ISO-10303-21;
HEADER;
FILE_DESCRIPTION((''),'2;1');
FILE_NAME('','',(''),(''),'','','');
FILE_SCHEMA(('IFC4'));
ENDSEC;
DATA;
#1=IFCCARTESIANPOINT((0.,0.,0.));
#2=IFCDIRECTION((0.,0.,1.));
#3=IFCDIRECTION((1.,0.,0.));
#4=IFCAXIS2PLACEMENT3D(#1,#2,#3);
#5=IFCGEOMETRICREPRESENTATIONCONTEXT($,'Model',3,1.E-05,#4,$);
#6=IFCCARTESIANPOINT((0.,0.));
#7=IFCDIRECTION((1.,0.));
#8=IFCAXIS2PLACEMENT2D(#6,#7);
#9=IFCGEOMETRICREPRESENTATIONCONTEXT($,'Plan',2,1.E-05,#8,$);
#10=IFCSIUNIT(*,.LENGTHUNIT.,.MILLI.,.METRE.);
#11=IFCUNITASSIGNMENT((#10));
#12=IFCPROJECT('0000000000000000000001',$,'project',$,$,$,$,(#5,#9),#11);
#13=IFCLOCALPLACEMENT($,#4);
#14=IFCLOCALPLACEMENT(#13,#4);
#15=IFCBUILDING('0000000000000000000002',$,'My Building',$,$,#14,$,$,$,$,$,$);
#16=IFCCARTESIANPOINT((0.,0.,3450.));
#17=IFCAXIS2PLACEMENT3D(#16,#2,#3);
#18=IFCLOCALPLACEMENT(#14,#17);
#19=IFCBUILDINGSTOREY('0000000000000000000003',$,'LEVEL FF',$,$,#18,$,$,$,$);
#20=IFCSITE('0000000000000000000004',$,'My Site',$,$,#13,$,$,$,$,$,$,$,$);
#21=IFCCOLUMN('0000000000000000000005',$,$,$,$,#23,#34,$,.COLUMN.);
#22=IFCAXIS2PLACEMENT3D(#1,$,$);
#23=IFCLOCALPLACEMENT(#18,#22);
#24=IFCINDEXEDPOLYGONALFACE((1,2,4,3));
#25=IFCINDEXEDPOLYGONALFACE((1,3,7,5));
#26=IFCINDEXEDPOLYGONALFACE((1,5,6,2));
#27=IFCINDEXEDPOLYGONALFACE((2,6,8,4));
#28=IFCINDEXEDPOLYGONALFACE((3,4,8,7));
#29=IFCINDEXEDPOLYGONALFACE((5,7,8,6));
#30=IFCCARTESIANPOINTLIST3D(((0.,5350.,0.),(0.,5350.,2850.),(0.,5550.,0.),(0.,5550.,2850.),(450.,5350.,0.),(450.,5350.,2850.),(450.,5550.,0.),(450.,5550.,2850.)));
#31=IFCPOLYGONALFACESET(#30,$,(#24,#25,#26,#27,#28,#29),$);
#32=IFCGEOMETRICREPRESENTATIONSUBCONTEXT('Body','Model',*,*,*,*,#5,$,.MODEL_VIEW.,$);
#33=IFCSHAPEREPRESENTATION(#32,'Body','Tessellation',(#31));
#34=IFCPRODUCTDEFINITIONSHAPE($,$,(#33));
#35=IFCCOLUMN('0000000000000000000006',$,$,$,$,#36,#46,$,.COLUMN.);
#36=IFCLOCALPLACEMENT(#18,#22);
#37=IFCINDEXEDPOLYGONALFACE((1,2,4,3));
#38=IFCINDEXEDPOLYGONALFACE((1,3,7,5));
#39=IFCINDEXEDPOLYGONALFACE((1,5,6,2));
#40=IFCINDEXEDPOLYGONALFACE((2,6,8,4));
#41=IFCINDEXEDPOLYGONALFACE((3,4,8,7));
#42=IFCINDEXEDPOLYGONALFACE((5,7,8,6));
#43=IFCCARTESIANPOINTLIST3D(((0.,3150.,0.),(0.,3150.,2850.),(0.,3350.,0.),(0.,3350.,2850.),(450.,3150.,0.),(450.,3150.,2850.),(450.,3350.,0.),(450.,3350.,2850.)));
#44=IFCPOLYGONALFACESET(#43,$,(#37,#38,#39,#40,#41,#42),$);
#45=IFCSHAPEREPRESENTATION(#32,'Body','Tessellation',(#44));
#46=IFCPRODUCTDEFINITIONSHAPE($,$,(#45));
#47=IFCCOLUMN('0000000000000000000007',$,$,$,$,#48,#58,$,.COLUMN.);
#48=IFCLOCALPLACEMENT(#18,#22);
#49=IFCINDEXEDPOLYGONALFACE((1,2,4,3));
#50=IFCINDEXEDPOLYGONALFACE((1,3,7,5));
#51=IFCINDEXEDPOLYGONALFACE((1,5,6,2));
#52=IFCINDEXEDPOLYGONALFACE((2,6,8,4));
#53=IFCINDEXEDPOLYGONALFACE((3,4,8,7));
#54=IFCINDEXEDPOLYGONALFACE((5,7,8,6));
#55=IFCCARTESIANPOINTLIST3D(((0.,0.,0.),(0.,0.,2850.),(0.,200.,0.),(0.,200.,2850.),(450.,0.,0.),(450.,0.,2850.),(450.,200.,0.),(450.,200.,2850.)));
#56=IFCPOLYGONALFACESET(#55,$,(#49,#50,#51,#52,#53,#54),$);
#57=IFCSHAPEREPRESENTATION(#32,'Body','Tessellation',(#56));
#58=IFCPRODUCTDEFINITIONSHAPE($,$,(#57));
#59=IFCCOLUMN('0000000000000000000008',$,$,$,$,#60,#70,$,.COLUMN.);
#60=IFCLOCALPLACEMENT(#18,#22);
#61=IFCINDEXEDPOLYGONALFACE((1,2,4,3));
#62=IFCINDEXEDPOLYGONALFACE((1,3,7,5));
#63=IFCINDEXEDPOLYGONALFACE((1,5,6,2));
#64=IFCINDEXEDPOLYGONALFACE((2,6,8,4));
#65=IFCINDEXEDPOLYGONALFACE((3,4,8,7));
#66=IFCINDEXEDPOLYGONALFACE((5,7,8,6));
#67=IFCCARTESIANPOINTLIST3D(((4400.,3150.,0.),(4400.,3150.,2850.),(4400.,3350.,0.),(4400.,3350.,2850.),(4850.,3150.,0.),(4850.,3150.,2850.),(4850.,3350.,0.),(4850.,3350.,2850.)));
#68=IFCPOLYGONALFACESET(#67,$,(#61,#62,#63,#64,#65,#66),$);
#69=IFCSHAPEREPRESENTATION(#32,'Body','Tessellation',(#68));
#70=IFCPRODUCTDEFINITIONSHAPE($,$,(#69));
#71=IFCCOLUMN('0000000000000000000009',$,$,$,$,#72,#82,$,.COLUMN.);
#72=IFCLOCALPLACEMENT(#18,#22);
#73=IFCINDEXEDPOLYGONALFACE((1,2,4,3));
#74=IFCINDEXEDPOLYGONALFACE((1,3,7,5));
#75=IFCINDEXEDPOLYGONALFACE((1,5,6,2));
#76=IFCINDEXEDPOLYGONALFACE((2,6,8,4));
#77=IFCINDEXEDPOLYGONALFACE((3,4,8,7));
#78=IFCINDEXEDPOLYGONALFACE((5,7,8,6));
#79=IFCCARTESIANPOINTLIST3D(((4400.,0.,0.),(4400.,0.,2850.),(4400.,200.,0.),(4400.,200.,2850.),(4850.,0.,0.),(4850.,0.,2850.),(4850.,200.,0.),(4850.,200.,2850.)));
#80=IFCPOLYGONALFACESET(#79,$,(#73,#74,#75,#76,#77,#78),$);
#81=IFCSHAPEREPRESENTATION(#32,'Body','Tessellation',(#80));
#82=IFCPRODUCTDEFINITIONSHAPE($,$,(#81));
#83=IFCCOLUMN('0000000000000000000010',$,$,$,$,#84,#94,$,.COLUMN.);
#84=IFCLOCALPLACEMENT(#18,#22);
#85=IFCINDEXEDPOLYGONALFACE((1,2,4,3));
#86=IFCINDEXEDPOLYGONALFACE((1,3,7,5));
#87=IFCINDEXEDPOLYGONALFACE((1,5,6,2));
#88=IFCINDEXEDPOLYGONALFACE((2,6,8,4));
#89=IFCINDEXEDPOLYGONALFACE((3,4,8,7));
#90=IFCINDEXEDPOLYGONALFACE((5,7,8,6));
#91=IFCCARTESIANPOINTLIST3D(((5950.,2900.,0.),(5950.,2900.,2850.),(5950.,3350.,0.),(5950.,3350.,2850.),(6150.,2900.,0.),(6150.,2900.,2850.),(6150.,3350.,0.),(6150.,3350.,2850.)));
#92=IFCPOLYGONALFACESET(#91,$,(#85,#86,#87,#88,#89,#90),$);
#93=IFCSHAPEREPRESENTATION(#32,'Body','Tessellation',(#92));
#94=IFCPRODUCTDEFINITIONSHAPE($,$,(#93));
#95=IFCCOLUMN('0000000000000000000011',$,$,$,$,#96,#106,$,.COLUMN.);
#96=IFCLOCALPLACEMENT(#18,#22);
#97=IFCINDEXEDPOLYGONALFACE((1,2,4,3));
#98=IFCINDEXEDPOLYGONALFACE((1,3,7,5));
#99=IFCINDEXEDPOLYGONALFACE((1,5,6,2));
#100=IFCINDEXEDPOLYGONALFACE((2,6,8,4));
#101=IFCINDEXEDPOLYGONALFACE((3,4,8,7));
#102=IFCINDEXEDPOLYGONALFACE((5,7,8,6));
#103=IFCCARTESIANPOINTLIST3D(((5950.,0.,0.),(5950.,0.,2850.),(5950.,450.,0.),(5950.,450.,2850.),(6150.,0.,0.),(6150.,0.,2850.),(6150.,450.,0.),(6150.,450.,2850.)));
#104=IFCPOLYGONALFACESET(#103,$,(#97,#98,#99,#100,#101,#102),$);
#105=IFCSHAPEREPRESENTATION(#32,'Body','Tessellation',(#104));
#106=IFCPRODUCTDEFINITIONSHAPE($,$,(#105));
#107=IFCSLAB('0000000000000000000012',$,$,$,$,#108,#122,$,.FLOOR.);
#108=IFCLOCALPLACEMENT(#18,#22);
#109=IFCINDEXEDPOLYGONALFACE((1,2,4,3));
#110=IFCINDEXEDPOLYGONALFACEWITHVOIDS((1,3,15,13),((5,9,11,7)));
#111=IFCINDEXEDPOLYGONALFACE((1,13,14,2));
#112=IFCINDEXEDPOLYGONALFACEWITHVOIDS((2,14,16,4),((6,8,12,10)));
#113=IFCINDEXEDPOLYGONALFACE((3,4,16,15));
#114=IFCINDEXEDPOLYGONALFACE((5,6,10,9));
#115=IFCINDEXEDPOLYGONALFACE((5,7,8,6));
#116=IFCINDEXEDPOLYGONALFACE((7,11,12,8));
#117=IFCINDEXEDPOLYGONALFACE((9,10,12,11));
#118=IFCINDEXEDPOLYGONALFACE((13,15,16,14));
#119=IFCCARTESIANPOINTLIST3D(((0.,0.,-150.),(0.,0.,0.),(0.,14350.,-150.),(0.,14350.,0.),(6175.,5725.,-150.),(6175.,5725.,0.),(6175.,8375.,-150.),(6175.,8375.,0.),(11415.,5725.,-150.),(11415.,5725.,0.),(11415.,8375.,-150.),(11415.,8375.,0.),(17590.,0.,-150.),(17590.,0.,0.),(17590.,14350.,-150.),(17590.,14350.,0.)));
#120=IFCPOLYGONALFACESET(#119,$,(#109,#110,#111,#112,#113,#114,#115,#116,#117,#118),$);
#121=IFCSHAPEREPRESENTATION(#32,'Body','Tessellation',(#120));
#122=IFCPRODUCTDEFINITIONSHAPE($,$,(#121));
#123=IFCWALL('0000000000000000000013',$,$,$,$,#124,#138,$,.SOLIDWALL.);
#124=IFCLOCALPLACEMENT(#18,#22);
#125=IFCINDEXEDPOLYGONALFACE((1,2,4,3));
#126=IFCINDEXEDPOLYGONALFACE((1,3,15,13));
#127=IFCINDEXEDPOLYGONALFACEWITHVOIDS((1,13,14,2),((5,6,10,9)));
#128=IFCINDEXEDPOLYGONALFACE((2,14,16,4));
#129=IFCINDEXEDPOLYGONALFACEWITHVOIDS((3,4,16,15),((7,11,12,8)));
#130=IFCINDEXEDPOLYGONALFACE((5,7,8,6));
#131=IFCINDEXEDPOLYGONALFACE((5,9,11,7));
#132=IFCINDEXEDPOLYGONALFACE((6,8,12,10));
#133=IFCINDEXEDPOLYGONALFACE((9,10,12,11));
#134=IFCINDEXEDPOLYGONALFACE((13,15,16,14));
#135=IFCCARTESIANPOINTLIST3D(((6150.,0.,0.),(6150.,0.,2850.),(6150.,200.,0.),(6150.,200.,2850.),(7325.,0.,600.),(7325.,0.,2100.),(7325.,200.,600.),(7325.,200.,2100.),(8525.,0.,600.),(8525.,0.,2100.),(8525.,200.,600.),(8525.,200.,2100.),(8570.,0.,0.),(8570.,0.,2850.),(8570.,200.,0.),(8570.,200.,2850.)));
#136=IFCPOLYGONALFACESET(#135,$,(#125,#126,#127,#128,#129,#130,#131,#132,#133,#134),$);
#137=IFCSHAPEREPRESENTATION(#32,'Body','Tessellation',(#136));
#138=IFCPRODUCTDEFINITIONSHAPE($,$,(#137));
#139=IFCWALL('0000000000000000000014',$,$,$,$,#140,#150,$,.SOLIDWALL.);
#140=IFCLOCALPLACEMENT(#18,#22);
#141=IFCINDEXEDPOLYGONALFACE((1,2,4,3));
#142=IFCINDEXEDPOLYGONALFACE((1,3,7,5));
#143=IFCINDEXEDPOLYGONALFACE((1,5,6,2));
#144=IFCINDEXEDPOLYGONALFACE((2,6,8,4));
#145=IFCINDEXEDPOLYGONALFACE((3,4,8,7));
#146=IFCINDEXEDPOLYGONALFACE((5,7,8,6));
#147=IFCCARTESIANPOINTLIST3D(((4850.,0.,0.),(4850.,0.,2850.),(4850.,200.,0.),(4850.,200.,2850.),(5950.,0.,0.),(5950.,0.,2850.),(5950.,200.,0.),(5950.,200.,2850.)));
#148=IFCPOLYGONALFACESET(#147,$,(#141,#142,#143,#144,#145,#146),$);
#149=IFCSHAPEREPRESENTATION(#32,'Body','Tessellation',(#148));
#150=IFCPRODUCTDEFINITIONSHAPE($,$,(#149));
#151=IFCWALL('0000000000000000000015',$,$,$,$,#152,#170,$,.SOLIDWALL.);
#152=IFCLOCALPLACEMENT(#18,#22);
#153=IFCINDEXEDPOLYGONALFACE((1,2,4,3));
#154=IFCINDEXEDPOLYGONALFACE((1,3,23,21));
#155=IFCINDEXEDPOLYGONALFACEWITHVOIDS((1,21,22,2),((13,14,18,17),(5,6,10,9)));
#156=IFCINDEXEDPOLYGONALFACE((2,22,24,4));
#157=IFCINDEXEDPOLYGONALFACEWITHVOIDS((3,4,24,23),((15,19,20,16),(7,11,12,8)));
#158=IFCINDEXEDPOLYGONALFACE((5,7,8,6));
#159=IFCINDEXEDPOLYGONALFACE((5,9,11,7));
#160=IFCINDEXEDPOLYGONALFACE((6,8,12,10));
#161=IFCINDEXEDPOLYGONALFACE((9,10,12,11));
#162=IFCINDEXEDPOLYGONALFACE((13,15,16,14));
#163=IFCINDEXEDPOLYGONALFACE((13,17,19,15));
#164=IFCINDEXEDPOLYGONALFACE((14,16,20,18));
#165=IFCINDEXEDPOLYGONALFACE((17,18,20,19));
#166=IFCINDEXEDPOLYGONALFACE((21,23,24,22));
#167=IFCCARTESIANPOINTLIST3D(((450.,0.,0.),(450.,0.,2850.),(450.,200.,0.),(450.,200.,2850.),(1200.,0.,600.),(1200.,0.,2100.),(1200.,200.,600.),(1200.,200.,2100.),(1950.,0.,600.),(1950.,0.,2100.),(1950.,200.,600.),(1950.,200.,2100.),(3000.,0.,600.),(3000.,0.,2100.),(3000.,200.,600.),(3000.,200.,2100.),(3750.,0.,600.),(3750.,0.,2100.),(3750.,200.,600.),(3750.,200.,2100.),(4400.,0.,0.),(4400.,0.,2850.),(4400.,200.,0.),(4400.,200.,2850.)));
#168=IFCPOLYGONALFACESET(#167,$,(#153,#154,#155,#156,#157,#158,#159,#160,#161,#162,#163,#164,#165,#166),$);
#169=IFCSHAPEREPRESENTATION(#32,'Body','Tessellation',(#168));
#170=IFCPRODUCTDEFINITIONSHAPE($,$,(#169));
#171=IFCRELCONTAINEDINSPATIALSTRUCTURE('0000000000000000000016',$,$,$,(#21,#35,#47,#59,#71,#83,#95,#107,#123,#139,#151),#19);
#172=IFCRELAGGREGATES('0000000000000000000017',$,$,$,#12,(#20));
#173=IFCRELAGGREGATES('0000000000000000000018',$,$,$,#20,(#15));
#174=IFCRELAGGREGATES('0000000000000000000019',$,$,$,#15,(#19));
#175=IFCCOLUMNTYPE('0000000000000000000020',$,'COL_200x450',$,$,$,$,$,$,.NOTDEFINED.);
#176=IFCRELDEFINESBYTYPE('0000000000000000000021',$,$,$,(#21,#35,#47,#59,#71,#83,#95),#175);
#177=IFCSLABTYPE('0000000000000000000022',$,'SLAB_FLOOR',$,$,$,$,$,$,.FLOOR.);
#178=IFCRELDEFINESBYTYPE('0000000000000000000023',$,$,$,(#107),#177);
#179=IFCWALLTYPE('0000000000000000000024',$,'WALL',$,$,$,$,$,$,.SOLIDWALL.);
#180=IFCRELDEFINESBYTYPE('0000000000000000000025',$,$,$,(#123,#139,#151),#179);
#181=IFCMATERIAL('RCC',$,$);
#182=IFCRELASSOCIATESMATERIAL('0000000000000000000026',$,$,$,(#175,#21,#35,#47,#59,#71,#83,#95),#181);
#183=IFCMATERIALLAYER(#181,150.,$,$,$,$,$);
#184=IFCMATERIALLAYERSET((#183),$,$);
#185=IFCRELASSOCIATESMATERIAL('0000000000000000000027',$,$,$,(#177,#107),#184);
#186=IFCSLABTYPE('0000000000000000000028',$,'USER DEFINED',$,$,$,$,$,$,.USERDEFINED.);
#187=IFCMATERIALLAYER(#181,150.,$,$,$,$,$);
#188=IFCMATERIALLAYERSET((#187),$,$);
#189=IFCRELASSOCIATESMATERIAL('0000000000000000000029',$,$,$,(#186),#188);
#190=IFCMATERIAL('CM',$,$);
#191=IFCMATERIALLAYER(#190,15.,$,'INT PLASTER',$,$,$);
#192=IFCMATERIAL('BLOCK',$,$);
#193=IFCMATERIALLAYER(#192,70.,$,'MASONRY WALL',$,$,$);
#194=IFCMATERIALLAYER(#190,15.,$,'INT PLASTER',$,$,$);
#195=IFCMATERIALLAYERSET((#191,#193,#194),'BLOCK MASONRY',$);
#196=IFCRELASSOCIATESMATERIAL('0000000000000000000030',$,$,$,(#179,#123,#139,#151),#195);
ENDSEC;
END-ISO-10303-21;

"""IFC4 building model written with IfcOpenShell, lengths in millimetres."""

from ifc_helpers import new_model, si_unit, frame, origin_with_axes, origin_2d_with_axis, place, context, subcontext, project, spatial, indexed_curve, rectangle, outline, extrude, material, layer, layer_set, layer_usage, material_profile, profile_set, profile_usage, type_object, element, save


model = new_model("IFC4")

# Units and contexts
model_context = context("Model", 3, precision=1e-05, world=origin_with_axes())
plan_context = context("Plan", 2, precision=1e-05, world=origin_2d_with_axis())
body_context = subcontext(model_context, "Body", "Model", "MODEL_VIEW")
ifc_project = project(units=[si_unit("LENGTHUNIT", "METRE", prefix="MILLI")], contexts=[model_context, plan_context])

# Site, building, storey
site_placement = place(None, origin_with_axes())
site = spatial("IfcSite", under=ifc_project, at=site_placement, Name="My Site")
building_placement = place(site_placement, origin_with_axes())
building = spatial("IfcBuilding", under=site, at=building_placement, Name="My Building")
storey_placement = place(building_placement, frame((0.0, 0.0, 3450.0), z_axis=(0.0, 0.0, 1.0), x_axis=(1.0, 0.0, 0.0)))
storey = spatial("IfcBuildingStorey", under=building, at=storey_placement, Name="LEVEL FF")

# Columns
ifc_material_1 = material(Name="RCC")
ifc_material_profile = material_profile(ifc_material_1, rectangle(XDim=200.0, YDim=450.0))
ifc_profile_set = profile_set([ifc_material_profile], Name="COL_200x450")
ifc_profile_usage_1 = profile_usage(ifc_profile_set)
column_type = type_object("IfcColumnType", Name="COL_200x450", PredefinedType="NOTDEFINED", material=ifc_profile_set)
column_1_placement = place(storey_placement, frame((225.0, 5450.0, 0.0), z_axis=(0.0, 0.0, 1.0), x_axis=(0.0, -1.0, 0.0)))
element("IfcColumn", 1, at=column_1_placement, inside=storey, type_object=column_type, material=ifc_profile_usage_1, PredefinedType="COLUMN", context=body_context, shape_type="SweptSolid", body=[
    extrude(rectangle(XDim=200.0, YDim=450.0), origin_with_axes(), (0.0, 0.0, 1.0), 2850.0),
])
ifc_profile_usage_2 = profile_usage(ifc_profile_set)
column_2_placement = place(storey_placement, frame((225.0, 3250.0, 0.0), z_axis=(0.0, 0.0, 1.0), x_axis=(0.0, -1.0, 0.0)))
element("IfcColumn", 2, at=column_2_placement, inside=storey, type_object=column_type, material=ifc_profile_usage_2, PredefinedType="COLUMN", context=body_context, shape_type="SweptSolid", body=[
    extrude(rectangle(XDim=200.0, YDim=450.0), origin_with_axes(), (0.0, 0.0, 1.0), 2850.0),
])
ifc_profile_usage_3 = profile_usage(ifc_profile_set)
column_3_placement = place(storey_placement, frame((225.0, 100.0, 0.0), z_axis=(0.0, 0.0, 1.0), x_axis=(0.0, -1.0, 0.0)))
element("IfcColumn", 3, at=column_3_placement, inside=storey, type_object=column_type, material=ifc_profile_usage_3, PredefinedType="COLUMN", context=body_context, shape_type="SweptSolid", body=[
    extrude(rectangle(XDim=200.0, YDim=450.0), origin_with_axes(), (0.0, 0.0, 1.0), 2850.0),
])
ifc_profile_usage_4 = profile_usage(ifc_profile_set)
column_4_placement = place(storey_placement, frame((4625.0, 3250.0, 0.0), z_axis=(0.0, 0.0, 1.0), x_axis=(0.0, -1.0, 0.0)))
element("IfcColumn", 4, at=column_4_placement, inside=storey, type_object=column_type, material=ifc_profile_usage_4, PredefinedType="COLUMN", context=body_context, shape_type="SweptSolid", body=[
    extrude(rectangle(XDim=200.0, YDim=450.0), origin_with_axes(), (0.0, 0.0, 1.0), 2850.0),
])
ifc_profile_usage_5 = profile_usage(ifc_profile_set)
column_5_placement = place(storey_placement, frame((4625.0, 100.0, 0.0), z_axis=(0.0, 0.0, 1.0), x_axis=(0.0, -1.0, 0.0)))
element("IfcColumn", 5, at=column_5_placement, inside=storey, type_object=column_type, material=ifc_profile_usage_5, PredefinedType="COLUMN", context=body_context, shape_type="SweptSolid", body=[
    extrude(rectangle(XDim=200.0, YDim=450.0), origin_with_axes(), (0.0, 0.0, 1.0), 2850.0),
])
ifc_profile_usage_6 = profile_usage(ifc_profile_set)
column_6_placement = place(storey_placement, frame((6050.0, 3125.0, 0.0), z_axis=(0.0, 0.0, 1.0), x_axis=(1.0, 0.0, 0.0)))
element("IfcColumn", 6, at=column_6_placement, inside=storey, type_object=column_type, material=ifc_profile_usage_6, PredefinedType="COLUMN", context=body_context, shape_type="SweptSolid", body=[
    extrude(rectangle(XDim=200.0, YDim=450.0), origin_with_axes(), (0.0, 0.0, 1.0), 2850.0),
])
ifc_profile_usage_7 = profile_usage(ifc_profile_set)
column_7_placement = place(storey_placement, frame((6050.0, 225.0, 0.0), z_axis=(0.0, 0.0, 1.0), x_axis=(1.0, 0.0, 0.0)))
element("IfcColumn", 7, at=column_7_placement, inside=storey, type_object=column_type, material=ifc_profile_usage_7, PredefinedType="COLUMN", context=body_context, shape_type="SweptSolid", body=[
    extrude(rectangle(XDim=200.0, YDim=450.0), origin_with_axes(), (0.0, 0.0, 1.0), 2850.0),
])

# Slab, opening
ifc_layer_1 = layer(ifc_material_1, 150.0)
ifc_layer_set_1 = layer_set([ifc_layer_1])
ifc_layer_usage_1 = layer_usage(ifc_layer_set_1, "AXIS3", "POSITIVE", 0.0)
slab_type_1 = type_object("IfcSlabType", Name="SLAB_FLOOR", PredefinedType="FLOOR", material=ifc_layer_set_1)
slab_placement = place(storey_placement, frame((0.0, 0.0, -150.0), z_axis=(0.0, 0.0, 1.0), x_axis=(1.0, 0.0, 0.0)))
slab = element("IfcSlab", 8, at=slab_placement, inside=storey, type_object=slab_type_1, material=ifc_layer_usage_1, PredefinedType="FLOOR", context=body_context, shape_type="SweptSolid", body=[
    extrude(outline(indexed_curve([(0.0, 14350.0), (17590.0, 14350.0), (17590.0, 0.0), (0.0, 0.0)])), None, (0.0, 0.0, 1.0), 150.0),
])
ifc_layer_2 = layer(ifc_material_1, 150.0)
ifc_layer_set_2 = layer_set([ifc_layer_2])
ifc_layer_usage_2 = layer_usage(ifc_layer_set_2, "AXIS3", "POSITIVE", 0.0)
slab_type_2 = type_object("IfcSlabType", Name="USER DEFINED", PredefinedType="USERDEFINED", material=ifc_layer_set_2)
opening_1_placement = place(slab_placement, origin_with_axes())
element("IfcOpeningElement", 9, at=opening_1_placement, cuts=slab, type_object=slab_type_2, material=ifc_layer_usage_2, ObjectType="FLOORCUTOUT", PredefinedType="OPENING", context=body_context, shape_type="SweptSolid", body=[
    extrude(outline(indexed_curve([(6175.0, 5725.0), (6175.0, 8375.0), (11415.0, 8375.0), (11415.0, 5725.0)])), None, (0.0, 0.0, 1.0), 150.0),
])

# Wall, opening
ifc_material_2 = material(Name="CM")
ifc_layer_3 = layer(ifc_material_2, 15.0, Name="INT PLASTER")
ifc_material_3 = material(Name="BLOCK")
ifc_layer_4 = layer(ifc_material_3, 70.0, Name="MASONRY WALL")
ifc_layer_5 = layer(ifc_material_2, 15.0, Name="INT PLASTER")
ifc_layer_set_3 = layer_set([ifc_layer_3, ifc_layer_4, ifc_layer_5], Name="BLOCK MASONRY")
ifc_layer_usage_3 = layer_usage(ifc_layer_set_3, "AXIS2", "POSITIVE", 0.0)
wall_type = type_object("IfcWallType", Name="WALL", PredefinedType="SOLIDWALL", material=ifc_layer_set_3)
wall_1_placement = place(storey_placement, frame((6150.0, 200.0, 0.0), z_axis=(0.0, 0.0, 1.0), x_axis=(0.0, -1.0, 0.0)))
wall_1 = element("IfcWall", 10, at=wall_1_placement, inside=storey, type_object=wall_type, material=ifc_layer_usage_3, PredefinedType="SOLIDWALL", context=body_context, shape_type="SweptSolid", body=[
    extrude(outline(indexed_curve([(0.0, 0.0), (0.0, 2420.0), (200.0, 2420.0), (200.0, 0.0), (0.0, 0.0)], self_intersect=False)), origin_with_axes(), (0.0, 0.0, 1.0), 2850.0),
])
opening_2_placement = place(wall_1_placement, frame((0.0, 2375.0, 600.0), z_axis=(0.0, 0.0, 1.0), x_axis=(0.0, -1.0, 0.0)))
element("IfcOpeningElement", 11, at=opening_2_placement, cuts=wall_1, PredefinedType="OPENING", context=body_context, shape_type="SweptSolid", body=[
    extrude(outline(indexed_curve([(0.0, 0.0), (0.0, 400.0), (1200.0, 400.0), (1200.0, 0.0), (0.0, 0.0)], self_intersect=False)), frame((0.0, -100.0, 0.0), z_axis=(0.0, 0.0, 1.0), x_axis=(1.0, 0.0, 0.0)), (0.0, 0.0, 1.0), 1500.0),
])

# Wall
ifc_layer_usage_4 = layer_usage(ifc_layer_set_3, "AXIS2", "POSITIVE", 0.0)
wall_2_placement = place(storey_placement, frame((4850.0, 200.0, 0.0), z_axis=(0.0, 0.0, 1.0), x_axis=(0.0, -1.0, 0.0)))
element("IfcWall", 12, at=wall_2_placement, inside=storey, type_object=wall_type, material=ifc_layer_usage_4, PredefinedType="SOLIDWALL", context=body_context, shape_type="SweptSolid", body=[
    extrude(outline(indexed_curve([(0.0, 0.0), (0.0, 1100.0), (200.0, 1100.0), (200.0, 0.0), (0.0, 0.0)], self_intersect=False)), origin_with_axes(), (0.0, 0.0, 1.0), 2850.0),
])

# Wall, openings
ifc_layer_usage_5 = layer_usage(ifc_layer_set_3, "AXIS2", "POSITIVE", 0.0)
wall_3_placement = place(storey_placement, frame((450.0, 200.0, 0.0), z_axis=(0.0, 0.0, 1.0), x_axis=(0.0, -1.0, 0.0)))
wall_3 = element("IfcWall", 13, at=wall_3_placement, inside=storey, type_object=wall_type, material=ifc_layer_usage_5, PredefinedType="SOLIDWALL", context=body_context, shape_type="SweptSolid", body=[
    extrude(outline(indexed_curve([(0.0, 0.0), (0.0, 3950.0), (200.0, 3950.0), (200.0, 0.0), (0.0, 0.0)], self_intersect=False)), origin_with_axes(), (0.0, 0.0, 1.0), 2850.0),
])
opening_3_placement = place(wall_3_placement, frame((0.0, 1500.0, 600.0), z_axis=(0.0, 0.0, 1.0), x_axis=(0.0, -1.0, 0.0)))
element("IfcOpeningElement", 14, at=opening_3_placement, cuts=wall_3, PredefinedType="OPENING", context=body_context, shape_type="SweptSolid", body=[
    extrude(outline(indexed_curve([(0.0, 0.0), (0.0, 400.0), (750.0, 400.0), (750.0, 0.0), (0.0, 0.0)], self_intersect=False)), frame((0.0, -100.0, 0.0), z_axis=(0.0, 0.0, 1.0), x_axis=(1.0, 0.0, 0.0)), (0.0, 0.0, 1.0), 1500.0),
])
opening_4_placement = place(wall_3_placement, frame((0.0, 3300.0, 600.0), z_axis=(0.0, 0.0, 1.0), x_axis=(0.0, -1.0, 0.0)))
element("IfcOpeningElement", 15, at=opening_4_placement, cuts=wall_3, PredefinedType="OPENING", context=body_context, shape_type="SweptSolid", body=[
    extrude(outline(indexed_curve([(0.0, 0.0), (0.0, 400.0), (750.0, 400.0), (750.0, 0.0), (0.0, 0.0)], self_intersect=False)), frame((0.0, -100.0, 0.0), z_axis=(0.0, 0.0, 1.0), x_axis=(1.0, 0.0, 0.0)), (0.0, 0.0, 1.0), 1500.0),
])

save(model, "model.ifc")
